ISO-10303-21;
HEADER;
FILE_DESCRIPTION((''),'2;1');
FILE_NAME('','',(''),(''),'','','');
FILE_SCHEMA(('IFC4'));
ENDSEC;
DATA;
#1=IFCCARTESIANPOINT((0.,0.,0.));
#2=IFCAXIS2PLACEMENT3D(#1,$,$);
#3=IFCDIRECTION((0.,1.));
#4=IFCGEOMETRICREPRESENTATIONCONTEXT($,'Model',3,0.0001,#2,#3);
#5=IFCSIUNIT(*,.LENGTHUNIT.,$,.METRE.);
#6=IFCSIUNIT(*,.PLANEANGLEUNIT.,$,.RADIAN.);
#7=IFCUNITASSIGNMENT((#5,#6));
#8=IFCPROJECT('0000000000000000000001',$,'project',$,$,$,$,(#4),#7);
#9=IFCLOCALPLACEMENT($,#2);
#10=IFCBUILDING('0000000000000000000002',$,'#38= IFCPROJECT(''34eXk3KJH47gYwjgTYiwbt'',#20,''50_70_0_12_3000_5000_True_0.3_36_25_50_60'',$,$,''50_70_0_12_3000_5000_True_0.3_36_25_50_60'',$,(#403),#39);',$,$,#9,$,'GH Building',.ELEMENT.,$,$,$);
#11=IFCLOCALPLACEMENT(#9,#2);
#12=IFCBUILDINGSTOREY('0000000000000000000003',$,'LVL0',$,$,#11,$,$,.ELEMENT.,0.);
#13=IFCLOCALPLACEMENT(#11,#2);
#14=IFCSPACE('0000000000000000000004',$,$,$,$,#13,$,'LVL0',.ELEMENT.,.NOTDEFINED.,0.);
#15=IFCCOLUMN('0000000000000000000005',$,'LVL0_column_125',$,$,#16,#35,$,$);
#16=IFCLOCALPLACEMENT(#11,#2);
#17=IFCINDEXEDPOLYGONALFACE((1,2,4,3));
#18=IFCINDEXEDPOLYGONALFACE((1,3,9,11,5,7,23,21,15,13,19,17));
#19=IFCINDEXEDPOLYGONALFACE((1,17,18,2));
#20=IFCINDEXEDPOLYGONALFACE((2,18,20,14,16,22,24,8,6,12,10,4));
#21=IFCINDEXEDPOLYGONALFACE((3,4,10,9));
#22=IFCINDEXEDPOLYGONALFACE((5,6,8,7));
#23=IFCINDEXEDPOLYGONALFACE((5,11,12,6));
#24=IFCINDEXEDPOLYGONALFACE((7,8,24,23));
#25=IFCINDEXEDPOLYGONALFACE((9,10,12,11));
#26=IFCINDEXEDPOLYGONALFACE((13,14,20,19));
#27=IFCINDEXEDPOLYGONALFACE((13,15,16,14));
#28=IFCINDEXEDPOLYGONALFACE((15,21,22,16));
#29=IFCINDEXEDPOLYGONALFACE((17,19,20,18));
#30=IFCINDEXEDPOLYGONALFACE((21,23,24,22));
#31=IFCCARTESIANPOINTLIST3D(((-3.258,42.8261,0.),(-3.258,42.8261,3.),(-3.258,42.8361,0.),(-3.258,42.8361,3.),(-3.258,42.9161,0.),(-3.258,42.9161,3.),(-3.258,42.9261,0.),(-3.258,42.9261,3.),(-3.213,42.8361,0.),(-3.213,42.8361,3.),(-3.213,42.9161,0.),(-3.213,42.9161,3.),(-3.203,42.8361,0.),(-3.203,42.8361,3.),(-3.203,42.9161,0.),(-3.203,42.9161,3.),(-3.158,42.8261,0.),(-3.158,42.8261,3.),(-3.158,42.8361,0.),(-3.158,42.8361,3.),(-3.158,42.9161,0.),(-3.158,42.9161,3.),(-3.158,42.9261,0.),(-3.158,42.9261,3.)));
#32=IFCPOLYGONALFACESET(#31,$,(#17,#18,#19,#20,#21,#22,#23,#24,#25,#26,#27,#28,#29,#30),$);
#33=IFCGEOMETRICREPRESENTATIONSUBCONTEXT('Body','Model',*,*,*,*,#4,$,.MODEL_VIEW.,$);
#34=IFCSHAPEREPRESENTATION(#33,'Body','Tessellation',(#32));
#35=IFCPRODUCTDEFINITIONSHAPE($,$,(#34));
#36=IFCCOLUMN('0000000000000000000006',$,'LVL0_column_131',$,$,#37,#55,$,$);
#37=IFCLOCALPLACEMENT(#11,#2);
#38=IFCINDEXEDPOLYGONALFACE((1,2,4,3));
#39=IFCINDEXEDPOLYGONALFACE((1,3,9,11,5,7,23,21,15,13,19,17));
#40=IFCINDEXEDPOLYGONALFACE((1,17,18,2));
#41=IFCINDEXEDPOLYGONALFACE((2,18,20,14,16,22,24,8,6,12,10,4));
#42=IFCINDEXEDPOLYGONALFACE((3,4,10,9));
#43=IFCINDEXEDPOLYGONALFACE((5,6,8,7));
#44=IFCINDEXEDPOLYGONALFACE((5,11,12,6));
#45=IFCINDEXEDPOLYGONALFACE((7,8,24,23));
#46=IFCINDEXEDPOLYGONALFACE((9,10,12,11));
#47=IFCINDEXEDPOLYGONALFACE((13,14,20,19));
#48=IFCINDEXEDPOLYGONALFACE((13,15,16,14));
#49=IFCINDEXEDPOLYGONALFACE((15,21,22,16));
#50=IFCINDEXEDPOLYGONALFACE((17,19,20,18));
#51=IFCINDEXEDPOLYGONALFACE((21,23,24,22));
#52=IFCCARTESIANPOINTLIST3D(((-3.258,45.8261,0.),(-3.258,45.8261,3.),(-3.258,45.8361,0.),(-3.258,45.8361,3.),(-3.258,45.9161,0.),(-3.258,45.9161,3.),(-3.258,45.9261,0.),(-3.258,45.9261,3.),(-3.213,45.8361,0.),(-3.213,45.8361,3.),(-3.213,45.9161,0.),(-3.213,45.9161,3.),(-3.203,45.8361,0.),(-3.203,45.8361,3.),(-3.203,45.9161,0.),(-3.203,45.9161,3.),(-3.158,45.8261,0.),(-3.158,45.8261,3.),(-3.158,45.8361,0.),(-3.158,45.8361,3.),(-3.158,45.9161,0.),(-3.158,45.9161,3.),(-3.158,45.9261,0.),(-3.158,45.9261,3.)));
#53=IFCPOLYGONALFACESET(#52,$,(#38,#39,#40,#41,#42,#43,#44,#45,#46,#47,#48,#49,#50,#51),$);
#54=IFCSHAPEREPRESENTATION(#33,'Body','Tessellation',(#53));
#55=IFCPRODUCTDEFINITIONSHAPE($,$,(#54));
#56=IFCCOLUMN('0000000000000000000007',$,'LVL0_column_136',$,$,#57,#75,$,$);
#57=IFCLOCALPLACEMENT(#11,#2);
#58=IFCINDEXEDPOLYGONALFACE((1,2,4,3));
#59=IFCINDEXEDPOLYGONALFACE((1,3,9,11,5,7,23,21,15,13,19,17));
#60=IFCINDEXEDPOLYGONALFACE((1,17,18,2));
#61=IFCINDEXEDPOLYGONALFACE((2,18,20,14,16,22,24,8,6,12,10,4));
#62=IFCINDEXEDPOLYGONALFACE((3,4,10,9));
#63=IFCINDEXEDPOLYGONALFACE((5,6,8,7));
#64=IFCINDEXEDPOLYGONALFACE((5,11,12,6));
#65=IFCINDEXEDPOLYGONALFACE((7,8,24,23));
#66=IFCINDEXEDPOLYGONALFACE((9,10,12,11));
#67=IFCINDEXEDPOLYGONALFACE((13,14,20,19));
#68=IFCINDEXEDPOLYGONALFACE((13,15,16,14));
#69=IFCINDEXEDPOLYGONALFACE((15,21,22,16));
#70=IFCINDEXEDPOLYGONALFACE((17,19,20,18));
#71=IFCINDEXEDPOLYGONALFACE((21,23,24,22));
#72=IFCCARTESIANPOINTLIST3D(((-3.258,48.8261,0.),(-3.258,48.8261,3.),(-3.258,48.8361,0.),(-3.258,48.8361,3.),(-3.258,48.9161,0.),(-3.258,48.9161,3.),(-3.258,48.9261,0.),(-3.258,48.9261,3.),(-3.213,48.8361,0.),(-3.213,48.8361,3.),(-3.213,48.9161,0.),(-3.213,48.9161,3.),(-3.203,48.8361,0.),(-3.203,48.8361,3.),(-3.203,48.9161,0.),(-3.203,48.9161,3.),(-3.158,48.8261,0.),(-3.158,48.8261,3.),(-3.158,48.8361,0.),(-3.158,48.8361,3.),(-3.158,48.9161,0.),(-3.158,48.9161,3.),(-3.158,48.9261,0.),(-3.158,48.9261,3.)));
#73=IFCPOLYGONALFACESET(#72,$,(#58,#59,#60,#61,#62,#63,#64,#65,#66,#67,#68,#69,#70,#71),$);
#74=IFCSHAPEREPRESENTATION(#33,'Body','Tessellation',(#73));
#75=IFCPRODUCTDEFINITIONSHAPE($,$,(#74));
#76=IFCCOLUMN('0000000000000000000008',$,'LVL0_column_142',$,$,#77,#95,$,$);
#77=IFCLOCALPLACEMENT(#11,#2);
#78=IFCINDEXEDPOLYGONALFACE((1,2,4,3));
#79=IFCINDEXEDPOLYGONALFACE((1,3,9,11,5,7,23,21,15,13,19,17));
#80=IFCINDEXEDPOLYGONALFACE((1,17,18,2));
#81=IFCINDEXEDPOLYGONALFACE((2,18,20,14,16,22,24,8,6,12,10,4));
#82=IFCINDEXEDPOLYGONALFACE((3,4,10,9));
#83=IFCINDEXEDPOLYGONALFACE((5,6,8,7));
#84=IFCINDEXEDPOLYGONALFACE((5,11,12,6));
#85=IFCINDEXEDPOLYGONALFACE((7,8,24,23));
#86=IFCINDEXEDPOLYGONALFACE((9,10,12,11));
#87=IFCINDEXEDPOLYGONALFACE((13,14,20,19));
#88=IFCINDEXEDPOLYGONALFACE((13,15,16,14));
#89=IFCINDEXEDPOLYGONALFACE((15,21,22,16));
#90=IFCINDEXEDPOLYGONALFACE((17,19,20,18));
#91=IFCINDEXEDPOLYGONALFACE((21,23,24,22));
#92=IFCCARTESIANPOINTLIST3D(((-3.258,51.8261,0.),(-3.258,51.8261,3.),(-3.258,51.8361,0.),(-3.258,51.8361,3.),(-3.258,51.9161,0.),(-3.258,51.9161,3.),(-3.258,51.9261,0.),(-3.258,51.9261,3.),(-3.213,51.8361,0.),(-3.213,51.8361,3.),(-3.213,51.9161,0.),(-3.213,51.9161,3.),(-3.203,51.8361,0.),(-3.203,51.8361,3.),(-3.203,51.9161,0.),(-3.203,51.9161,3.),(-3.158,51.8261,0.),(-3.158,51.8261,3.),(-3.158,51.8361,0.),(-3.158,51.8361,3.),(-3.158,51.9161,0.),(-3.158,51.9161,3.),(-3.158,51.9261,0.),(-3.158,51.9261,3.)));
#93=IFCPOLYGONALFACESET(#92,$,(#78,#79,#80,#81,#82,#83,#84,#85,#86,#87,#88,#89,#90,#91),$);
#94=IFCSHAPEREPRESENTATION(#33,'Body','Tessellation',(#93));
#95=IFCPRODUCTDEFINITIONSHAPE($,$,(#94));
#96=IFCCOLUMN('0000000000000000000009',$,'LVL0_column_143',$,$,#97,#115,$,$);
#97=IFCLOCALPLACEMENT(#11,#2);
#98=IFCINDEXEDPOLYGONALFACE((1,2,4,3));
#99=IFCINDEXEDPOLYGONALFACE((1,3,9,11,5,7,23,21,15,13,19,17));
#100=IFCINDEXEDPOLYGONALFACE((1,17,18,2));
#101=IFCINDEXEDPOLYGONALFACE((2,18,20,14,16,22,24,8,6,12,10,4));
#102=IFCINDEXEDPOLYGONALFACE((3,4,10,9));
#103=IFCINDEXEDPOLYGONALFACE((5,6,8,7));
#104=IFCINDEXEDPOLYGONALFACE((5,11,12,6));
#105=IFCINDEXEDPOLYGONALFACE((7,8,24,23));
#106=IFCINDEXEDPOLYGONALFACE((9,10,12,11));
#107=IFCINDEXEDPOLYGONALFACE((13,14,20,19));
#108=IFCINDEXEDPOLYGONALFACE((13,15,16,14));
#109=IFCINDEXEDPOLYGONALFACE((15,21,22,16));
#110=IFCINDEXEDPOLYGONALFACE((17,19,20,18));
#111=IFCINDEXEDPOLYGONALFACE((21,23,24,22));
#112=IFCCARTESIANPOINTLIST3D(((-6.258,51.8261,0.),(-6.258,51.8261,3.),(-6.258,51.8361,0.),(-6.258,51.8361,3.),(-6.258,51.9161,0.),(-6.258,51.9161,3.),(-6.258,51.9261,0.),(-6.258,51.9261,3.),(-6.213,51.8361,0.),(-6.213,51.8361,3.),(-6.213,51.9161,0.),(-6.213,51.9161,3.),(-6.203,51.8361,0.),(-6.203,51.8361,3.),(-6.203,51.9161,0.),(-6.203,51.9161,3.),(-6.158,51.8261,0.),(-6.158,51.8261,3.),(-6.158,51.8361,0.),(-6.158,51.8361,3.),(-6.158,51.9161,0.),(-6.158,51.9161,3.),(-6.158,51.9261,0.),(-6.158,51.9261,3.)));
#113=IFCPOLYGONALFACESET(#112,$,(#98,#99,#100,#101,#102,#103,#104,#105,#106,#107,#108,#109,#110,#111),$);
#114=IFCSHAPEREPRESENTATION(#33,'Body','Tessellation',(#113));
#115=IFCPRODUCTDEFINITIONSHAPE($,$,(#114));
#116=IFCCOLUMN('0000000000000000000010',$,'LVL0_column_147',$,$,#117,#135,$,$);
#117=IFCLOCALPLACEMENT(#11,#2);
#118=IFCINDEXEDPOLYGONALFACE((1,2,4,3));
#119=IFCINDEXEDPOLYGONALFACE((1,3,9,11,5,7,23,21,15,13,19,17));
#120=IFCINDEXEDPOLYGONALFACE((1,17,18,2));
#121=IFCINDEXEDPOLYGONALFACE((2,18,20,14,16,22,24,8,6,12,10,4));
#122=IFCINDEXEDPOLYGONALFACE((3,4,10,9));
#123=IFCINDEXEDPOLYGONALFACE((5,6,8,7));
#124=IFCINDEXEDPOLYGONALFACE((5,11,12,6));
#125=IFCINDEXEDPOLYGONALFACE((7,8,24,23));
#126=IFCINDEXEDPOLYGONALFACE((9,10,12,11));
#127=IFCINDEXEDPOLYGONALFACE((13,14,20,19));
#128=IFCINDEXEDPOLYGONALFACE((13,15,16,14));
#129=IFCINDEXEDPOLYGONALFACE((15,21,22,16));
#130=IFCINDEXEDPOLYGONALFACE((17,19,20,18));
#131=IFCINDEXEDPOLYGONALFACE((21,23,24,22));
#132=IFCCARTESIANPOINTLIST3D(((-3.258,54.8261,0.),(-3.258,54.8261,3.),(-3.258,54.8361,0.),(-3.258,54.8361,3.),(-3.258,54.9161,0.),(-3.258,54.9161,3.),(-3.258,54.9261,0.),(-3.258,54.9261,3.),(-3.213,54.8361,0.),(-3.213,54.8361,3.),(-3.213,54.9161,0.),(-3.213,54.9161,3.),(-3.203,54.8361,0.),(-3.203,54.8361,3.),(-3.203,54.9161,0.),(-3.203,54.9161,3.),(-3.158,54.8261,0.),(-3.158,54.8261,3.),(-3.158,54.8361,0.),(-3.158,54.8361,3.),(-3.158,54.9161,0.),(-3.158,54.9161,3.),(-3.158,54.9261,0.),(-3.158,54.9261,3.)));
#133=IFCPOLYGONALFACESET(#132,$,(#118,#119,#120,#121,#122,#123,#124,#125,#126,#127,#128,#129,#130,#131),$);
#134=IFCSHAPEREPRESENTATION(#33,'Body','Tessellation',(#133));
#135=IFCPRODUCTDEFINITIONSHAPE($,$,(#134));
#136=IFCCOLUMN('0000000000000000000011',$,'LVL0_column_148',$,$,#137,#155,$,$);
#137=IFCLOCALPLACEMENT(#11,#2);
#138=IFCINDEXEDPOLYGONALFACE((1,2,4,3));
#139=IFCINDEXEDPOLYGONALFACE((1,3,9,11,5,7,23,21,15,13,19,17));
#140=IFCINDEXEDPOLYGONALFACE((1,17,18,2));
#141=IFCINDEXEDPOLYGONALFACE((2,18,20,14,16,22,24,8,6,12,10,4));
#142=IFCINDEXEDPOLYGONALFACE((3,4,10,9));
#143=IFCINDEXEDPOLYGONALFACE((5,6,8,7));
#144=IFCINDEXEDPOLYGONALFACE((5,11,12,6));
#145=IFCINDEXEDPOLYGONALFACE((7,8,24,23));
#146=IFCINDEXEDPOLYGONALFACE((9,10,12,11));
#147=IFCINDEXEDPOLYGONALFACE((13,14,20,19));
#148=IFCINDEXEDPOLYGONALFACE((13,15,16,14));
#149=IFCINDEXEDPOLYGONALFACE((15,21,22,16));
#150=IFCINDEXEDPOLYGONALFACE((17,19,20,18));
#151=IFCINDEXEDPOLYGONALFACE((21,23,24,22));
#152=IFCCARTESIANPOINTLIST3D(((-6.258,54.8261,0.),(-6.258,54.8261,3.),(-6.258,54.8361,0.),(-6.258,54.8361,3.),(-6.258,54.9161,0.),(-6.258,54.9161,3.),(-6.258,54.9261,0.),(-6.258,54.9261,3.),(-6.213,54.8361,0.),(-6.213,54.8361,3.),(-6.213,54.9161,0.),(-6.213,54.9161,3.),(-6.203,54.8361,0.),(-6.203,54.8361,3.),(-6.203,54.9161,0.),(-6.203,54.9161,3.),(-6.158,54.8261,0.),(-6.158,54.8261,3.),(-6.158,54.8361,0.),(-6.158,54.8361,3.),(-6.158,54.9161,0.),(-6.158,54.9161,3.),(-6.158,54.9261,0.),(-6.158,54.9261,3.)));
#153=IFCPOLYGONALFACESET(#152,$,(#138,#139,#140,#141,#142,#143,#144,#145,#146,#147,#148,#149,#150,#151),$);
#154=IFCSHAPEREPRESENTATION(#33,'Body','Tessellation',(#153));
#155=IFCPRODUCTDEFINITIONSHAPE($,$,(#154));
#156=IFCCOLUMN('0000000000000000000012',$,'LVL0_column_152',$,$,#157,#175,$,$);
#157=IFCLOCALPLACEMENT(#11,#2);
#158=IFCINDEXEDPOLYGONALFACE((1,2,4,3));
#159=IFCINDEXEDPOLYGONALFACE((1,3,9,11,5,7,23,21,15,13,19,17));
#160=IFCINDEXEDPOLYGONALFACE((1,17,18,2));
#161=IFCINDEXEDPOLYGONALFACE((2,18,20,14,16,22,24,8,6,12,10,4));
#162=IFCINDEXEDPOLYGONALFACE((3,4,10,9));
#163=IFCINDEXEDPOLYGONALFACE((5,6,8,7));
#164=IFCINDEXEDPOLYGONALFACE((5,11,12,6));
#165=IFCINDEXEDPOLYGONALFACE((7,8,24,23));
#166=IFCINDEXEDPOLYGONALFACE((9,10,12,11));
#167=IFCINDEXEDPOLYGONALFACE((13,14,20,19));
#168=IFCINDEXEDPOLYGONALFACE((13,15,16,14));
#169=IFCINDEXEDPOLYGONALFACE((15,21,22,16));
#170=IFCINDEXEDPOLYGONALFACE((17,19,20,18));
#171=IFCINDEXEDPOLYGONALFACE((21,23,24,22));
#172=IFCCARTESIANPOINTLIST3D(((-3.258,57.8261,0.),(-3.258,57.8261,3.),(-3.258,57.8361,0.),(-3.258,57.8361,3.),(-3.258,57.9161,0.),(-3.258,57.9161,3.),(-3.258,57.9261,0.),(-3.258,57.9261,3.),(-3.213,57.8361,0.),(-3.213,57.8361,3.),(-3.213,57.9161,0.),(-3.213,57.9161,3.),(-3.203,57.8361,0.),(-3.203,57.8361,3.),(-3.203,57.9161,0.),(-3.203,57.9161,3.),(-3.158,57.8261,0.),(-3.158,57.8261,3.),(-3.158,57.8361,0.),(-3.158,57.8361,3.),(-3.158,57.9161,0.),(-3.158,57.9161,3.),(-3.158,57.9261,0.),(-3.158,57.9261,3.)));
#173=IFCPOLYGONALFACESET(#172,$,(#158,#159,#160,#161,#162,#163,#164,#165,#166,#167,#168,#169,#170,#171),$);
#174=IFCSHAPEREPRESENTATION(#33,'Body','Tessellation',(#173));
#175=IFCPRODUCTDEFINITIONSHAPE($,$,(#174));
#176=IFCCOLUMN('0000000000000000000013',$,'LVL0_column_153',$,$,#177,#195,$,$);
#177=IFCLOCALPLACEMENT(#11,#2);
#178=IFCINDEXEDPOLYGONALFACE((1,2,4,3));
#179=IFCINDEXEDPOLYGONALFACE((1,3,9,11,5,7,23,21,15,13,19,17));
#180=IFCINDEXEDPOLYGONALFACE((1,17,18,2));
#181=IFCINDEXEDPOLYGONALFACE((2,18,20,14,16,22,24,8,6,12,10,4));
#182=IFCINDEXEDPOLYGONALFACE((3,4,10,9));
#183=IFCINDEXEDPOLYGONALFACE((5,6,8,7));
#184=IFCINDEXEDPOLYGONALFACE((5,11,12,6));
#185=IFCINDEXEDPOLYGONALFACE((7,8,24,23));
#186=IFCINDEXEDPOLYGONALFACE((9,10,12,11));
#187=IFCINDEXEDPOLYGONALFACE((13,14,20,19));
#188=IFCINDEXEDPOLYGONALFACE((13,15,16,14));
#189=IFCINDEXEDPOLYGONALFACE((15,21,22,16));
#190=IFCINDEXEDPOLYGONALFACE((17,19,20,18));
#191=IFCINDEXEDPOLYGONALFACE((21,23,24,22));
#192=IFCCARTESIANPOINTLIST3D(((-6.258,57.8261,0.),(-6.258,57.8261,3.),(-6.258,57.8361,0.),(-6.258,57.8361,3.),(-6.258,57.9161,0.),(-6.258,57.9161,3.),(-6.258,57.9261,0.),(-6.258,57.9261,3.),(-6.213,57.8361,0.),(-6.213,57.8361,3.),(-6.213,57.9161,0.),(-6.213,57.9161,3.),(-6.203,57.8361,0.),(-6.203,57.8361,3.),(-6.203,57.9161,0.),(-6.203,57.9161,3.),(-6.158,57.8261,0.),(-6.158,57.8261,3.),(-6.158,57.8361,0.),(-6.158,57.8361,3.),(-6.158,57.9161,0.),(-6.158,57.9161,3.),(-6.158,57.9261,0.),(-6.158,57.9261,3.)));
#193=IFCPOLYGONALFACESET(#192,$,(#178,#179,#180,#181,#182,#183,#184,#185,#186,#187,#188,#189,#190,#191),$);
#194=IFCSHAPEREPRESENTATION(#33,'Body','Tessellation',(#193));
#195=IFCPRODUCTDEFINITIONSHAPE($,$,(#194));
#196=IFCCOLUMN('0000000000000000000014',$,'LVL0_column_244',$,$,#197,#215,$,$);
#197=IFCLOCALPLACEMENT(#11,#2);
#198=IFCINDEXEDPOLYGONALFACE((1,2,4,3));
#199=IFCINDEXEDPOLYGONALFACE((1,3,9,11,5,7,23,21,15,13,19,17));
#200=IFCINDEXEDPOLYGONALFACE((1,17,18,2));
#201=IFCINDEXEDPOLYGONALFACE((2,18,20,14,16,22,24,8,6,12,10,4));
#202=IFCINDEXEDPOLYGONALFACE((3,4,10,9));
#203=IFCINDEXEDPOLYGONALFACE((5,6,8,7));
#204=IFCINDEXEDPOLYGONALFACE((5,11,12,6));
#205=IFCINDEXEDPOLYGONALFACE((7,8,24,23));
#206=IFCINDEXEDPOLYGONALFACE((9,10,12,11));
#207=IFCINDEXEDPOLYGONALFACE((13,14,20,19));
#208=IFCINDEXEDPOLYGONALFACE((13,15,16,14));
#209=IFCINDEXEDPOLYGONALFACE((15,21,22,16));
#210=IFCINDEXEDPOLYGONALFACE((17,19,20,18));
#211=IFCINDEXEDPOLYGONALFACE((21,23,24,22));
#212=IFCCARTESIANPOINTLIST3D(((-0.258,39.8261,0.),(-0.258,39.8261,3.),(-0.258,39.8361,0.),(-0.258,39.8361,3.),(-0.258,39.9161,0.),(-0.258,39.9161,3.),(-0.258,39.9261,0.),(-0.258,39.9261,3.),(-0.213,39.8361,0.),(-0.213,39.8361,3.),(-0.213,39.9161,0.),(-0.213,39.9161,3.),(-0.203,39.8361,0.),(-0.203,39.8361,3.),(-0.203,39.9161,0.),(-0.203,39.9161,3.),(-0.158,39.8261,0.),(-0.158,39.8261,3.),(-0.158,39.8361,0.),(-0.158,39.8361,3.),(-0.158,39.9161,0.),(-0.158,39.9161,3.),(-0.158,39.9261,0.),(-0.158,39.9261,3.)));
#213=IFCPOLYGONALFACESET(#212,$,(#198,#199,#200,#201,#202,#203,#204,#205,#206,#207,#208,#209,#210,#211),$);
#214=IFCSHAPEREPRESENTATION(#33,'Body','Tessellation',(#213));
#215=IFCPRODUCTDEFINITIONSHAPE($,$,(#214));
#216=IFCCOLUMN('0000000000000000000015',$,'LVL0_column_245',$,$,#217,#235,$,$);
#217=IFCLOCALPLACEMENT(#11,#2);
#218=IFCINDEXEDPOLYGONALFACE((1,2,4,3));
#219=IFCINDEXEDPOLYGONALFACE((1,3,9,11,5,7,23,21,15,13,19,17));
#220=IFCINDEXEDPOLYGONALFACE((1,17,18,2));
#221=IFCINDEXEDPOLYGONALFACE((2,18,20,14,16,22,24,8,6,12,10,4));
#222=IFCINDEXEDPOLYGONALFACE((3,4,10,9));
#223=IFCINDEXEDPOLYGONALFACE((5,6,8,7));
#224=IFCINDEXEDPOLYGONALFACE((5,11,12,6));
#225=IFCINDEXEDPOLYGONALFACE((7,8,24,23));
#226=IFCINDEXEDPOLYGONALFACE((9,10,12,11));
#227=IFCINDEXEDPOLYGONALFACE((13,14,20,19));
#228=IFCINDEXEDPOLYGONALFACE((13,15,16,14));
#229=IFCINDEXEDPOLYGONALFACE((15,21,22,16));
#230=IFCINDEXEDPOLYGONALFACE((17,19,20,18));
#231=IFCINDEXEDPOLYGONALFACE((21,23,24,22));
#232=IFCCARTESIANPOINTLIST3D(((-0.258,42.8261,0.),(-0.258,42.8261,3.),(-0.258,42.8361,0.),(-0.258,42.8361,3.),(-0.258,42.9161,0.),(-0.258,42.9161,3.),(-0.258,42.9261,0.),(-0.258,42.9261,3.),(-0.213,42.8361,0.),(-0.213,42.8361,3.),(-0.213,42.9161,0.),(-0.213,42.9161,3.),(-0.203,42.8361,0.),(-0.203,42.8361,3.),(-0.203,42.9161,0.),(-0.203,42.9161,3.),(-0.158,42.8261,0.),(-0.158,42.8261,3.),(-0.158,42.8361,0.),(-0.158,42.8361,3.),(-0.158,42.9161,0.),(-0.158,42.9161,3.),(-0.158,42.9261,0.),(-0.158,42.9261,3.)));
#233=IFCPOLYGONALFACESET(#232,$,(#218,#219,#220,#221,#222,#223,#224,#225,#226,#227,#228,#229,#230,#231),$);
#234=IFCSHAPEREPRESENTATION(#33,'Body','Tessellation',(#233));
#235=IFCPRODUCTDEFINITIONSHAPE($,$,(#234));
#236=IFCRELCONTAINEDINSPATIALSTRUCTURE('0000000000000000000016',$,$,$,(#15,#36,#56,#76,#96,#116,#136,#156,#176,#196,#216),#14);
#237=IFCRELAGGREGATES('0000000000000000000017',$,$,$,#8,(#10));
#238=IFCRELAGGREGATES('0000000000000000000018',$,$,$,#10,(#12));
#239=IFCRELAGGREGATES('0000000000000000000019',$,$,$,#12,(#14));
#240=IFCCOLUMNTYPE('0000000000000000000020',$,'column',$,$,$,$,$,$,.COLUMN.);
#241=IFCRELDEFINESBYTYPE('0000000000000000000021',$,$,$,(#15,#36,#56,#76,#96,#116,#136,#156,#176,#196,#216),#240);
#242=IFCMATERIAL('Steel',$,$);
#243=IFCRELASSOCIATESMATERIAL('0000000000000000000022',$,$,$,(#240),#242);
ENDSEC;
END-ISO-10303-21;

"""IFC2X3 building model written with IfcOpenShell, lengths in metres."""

from ifc_helpers import new_model, si_unit, direction, frame, origin, origin_2d, place, context, subcontext, project, spatial, i_section, extrude, material, type_object, element, save


model = new_model("IFC2X3")

# Units and contexts
model_context = context("Model", 3, precision=0.0001, world=origin(), true_north=direction((0.0, 1.0)))
body_context = subcontext(model_context, "Body", "Model", "MODEL_VIEW")
ifc_project = project(units=[si_unit("LENGTHUNIT", "METRE"), si_unit("PLANEANGLEUNIT", "RADIAN")], contexts=[model_context])

# Building, storey, space
building_placement = place(None, origin())
building = spatial("IfcBuilding", under=ifc_project, at=building_placement, Name="#38= IFCPROJECT('34eXk3KJH47gYwjgTYiwbt',#20,'50_70_0_12_3000_5000_True_0.3_36_25_50_60',$,$,'50_70_0_12_3000_5000_True_0.3_36_25_50_60',$,(#403),#39);", LongName="GH Building", CompositionType="ELEMENT")
storey_placement = place(building_placement, origin())
storey = spatial("IfcBuildingStorey", under=building, at=storey_placement, Name="LVL0", CompositionType="ELEMENT", Elevation=0.0)
space_placement = place(storey_placement, origin())
space = spatial("IfcSpace", under=storey, at=space_placement, LongName="LVL0", CompositionType="ELEMENT", InteriorOrExteriorSpace="NOTDEFINED", ElevationWithFlooring=0.0)

# Columns
ifc_material_1 = material(Name="Steel")
column_type = type_object("IfcColumnType", Name="column", PredefinedType="COLUMN", material=ifc_material_1)
for number, where, name in (
    (1, (-3.208, 42.8761, 0.0), "LVL0_column_125"),
    (2, (-3.208, 45.8761, 0.0), "LVL0_column_131"),
    (3, (-3.208, 48.8761, 0.0), "LVL0_column_136"),
    (4, (-3.208, 51.8761, 0.0), "LVL0_column_142"),
    (5, (-6.208, 51.8761, 0.0), "LVL0_column_143"),
    (6, (-3.208, 54.8761, 0.0), "LVL0_column_147"),
    (7, (-6.208, 54.8761, 0.0), "LVL0_column_148"),
    (8, (-3.208, 57.8761, 0.0), "LVL0_column_152"),
    (9, (-6.208, 57.8761, 0.0), "LVL0_column_153"),
    (10, (-0.208, 39.8761, 0.0), "LVL0_column_244"),
    (11, (-0.208, 42.8761, 0.0), "LVL0_column_245"),
):
    element("IfcColumn", number, at=place(space_placement, frame(where)), inside=space, type_object=column_type, Name=name, context=body_context, shape_type="SweptSolid", body=[
        extrude(i_section(OverallWidth=0.1, OverallDepth=0.1, WebThickness=0.01, FlangeThickness=0.01, at=origin_2d()), origin(), (0.0, 0.0, 1.0), 3.0),
    ])

save(model, "model.ifc")
